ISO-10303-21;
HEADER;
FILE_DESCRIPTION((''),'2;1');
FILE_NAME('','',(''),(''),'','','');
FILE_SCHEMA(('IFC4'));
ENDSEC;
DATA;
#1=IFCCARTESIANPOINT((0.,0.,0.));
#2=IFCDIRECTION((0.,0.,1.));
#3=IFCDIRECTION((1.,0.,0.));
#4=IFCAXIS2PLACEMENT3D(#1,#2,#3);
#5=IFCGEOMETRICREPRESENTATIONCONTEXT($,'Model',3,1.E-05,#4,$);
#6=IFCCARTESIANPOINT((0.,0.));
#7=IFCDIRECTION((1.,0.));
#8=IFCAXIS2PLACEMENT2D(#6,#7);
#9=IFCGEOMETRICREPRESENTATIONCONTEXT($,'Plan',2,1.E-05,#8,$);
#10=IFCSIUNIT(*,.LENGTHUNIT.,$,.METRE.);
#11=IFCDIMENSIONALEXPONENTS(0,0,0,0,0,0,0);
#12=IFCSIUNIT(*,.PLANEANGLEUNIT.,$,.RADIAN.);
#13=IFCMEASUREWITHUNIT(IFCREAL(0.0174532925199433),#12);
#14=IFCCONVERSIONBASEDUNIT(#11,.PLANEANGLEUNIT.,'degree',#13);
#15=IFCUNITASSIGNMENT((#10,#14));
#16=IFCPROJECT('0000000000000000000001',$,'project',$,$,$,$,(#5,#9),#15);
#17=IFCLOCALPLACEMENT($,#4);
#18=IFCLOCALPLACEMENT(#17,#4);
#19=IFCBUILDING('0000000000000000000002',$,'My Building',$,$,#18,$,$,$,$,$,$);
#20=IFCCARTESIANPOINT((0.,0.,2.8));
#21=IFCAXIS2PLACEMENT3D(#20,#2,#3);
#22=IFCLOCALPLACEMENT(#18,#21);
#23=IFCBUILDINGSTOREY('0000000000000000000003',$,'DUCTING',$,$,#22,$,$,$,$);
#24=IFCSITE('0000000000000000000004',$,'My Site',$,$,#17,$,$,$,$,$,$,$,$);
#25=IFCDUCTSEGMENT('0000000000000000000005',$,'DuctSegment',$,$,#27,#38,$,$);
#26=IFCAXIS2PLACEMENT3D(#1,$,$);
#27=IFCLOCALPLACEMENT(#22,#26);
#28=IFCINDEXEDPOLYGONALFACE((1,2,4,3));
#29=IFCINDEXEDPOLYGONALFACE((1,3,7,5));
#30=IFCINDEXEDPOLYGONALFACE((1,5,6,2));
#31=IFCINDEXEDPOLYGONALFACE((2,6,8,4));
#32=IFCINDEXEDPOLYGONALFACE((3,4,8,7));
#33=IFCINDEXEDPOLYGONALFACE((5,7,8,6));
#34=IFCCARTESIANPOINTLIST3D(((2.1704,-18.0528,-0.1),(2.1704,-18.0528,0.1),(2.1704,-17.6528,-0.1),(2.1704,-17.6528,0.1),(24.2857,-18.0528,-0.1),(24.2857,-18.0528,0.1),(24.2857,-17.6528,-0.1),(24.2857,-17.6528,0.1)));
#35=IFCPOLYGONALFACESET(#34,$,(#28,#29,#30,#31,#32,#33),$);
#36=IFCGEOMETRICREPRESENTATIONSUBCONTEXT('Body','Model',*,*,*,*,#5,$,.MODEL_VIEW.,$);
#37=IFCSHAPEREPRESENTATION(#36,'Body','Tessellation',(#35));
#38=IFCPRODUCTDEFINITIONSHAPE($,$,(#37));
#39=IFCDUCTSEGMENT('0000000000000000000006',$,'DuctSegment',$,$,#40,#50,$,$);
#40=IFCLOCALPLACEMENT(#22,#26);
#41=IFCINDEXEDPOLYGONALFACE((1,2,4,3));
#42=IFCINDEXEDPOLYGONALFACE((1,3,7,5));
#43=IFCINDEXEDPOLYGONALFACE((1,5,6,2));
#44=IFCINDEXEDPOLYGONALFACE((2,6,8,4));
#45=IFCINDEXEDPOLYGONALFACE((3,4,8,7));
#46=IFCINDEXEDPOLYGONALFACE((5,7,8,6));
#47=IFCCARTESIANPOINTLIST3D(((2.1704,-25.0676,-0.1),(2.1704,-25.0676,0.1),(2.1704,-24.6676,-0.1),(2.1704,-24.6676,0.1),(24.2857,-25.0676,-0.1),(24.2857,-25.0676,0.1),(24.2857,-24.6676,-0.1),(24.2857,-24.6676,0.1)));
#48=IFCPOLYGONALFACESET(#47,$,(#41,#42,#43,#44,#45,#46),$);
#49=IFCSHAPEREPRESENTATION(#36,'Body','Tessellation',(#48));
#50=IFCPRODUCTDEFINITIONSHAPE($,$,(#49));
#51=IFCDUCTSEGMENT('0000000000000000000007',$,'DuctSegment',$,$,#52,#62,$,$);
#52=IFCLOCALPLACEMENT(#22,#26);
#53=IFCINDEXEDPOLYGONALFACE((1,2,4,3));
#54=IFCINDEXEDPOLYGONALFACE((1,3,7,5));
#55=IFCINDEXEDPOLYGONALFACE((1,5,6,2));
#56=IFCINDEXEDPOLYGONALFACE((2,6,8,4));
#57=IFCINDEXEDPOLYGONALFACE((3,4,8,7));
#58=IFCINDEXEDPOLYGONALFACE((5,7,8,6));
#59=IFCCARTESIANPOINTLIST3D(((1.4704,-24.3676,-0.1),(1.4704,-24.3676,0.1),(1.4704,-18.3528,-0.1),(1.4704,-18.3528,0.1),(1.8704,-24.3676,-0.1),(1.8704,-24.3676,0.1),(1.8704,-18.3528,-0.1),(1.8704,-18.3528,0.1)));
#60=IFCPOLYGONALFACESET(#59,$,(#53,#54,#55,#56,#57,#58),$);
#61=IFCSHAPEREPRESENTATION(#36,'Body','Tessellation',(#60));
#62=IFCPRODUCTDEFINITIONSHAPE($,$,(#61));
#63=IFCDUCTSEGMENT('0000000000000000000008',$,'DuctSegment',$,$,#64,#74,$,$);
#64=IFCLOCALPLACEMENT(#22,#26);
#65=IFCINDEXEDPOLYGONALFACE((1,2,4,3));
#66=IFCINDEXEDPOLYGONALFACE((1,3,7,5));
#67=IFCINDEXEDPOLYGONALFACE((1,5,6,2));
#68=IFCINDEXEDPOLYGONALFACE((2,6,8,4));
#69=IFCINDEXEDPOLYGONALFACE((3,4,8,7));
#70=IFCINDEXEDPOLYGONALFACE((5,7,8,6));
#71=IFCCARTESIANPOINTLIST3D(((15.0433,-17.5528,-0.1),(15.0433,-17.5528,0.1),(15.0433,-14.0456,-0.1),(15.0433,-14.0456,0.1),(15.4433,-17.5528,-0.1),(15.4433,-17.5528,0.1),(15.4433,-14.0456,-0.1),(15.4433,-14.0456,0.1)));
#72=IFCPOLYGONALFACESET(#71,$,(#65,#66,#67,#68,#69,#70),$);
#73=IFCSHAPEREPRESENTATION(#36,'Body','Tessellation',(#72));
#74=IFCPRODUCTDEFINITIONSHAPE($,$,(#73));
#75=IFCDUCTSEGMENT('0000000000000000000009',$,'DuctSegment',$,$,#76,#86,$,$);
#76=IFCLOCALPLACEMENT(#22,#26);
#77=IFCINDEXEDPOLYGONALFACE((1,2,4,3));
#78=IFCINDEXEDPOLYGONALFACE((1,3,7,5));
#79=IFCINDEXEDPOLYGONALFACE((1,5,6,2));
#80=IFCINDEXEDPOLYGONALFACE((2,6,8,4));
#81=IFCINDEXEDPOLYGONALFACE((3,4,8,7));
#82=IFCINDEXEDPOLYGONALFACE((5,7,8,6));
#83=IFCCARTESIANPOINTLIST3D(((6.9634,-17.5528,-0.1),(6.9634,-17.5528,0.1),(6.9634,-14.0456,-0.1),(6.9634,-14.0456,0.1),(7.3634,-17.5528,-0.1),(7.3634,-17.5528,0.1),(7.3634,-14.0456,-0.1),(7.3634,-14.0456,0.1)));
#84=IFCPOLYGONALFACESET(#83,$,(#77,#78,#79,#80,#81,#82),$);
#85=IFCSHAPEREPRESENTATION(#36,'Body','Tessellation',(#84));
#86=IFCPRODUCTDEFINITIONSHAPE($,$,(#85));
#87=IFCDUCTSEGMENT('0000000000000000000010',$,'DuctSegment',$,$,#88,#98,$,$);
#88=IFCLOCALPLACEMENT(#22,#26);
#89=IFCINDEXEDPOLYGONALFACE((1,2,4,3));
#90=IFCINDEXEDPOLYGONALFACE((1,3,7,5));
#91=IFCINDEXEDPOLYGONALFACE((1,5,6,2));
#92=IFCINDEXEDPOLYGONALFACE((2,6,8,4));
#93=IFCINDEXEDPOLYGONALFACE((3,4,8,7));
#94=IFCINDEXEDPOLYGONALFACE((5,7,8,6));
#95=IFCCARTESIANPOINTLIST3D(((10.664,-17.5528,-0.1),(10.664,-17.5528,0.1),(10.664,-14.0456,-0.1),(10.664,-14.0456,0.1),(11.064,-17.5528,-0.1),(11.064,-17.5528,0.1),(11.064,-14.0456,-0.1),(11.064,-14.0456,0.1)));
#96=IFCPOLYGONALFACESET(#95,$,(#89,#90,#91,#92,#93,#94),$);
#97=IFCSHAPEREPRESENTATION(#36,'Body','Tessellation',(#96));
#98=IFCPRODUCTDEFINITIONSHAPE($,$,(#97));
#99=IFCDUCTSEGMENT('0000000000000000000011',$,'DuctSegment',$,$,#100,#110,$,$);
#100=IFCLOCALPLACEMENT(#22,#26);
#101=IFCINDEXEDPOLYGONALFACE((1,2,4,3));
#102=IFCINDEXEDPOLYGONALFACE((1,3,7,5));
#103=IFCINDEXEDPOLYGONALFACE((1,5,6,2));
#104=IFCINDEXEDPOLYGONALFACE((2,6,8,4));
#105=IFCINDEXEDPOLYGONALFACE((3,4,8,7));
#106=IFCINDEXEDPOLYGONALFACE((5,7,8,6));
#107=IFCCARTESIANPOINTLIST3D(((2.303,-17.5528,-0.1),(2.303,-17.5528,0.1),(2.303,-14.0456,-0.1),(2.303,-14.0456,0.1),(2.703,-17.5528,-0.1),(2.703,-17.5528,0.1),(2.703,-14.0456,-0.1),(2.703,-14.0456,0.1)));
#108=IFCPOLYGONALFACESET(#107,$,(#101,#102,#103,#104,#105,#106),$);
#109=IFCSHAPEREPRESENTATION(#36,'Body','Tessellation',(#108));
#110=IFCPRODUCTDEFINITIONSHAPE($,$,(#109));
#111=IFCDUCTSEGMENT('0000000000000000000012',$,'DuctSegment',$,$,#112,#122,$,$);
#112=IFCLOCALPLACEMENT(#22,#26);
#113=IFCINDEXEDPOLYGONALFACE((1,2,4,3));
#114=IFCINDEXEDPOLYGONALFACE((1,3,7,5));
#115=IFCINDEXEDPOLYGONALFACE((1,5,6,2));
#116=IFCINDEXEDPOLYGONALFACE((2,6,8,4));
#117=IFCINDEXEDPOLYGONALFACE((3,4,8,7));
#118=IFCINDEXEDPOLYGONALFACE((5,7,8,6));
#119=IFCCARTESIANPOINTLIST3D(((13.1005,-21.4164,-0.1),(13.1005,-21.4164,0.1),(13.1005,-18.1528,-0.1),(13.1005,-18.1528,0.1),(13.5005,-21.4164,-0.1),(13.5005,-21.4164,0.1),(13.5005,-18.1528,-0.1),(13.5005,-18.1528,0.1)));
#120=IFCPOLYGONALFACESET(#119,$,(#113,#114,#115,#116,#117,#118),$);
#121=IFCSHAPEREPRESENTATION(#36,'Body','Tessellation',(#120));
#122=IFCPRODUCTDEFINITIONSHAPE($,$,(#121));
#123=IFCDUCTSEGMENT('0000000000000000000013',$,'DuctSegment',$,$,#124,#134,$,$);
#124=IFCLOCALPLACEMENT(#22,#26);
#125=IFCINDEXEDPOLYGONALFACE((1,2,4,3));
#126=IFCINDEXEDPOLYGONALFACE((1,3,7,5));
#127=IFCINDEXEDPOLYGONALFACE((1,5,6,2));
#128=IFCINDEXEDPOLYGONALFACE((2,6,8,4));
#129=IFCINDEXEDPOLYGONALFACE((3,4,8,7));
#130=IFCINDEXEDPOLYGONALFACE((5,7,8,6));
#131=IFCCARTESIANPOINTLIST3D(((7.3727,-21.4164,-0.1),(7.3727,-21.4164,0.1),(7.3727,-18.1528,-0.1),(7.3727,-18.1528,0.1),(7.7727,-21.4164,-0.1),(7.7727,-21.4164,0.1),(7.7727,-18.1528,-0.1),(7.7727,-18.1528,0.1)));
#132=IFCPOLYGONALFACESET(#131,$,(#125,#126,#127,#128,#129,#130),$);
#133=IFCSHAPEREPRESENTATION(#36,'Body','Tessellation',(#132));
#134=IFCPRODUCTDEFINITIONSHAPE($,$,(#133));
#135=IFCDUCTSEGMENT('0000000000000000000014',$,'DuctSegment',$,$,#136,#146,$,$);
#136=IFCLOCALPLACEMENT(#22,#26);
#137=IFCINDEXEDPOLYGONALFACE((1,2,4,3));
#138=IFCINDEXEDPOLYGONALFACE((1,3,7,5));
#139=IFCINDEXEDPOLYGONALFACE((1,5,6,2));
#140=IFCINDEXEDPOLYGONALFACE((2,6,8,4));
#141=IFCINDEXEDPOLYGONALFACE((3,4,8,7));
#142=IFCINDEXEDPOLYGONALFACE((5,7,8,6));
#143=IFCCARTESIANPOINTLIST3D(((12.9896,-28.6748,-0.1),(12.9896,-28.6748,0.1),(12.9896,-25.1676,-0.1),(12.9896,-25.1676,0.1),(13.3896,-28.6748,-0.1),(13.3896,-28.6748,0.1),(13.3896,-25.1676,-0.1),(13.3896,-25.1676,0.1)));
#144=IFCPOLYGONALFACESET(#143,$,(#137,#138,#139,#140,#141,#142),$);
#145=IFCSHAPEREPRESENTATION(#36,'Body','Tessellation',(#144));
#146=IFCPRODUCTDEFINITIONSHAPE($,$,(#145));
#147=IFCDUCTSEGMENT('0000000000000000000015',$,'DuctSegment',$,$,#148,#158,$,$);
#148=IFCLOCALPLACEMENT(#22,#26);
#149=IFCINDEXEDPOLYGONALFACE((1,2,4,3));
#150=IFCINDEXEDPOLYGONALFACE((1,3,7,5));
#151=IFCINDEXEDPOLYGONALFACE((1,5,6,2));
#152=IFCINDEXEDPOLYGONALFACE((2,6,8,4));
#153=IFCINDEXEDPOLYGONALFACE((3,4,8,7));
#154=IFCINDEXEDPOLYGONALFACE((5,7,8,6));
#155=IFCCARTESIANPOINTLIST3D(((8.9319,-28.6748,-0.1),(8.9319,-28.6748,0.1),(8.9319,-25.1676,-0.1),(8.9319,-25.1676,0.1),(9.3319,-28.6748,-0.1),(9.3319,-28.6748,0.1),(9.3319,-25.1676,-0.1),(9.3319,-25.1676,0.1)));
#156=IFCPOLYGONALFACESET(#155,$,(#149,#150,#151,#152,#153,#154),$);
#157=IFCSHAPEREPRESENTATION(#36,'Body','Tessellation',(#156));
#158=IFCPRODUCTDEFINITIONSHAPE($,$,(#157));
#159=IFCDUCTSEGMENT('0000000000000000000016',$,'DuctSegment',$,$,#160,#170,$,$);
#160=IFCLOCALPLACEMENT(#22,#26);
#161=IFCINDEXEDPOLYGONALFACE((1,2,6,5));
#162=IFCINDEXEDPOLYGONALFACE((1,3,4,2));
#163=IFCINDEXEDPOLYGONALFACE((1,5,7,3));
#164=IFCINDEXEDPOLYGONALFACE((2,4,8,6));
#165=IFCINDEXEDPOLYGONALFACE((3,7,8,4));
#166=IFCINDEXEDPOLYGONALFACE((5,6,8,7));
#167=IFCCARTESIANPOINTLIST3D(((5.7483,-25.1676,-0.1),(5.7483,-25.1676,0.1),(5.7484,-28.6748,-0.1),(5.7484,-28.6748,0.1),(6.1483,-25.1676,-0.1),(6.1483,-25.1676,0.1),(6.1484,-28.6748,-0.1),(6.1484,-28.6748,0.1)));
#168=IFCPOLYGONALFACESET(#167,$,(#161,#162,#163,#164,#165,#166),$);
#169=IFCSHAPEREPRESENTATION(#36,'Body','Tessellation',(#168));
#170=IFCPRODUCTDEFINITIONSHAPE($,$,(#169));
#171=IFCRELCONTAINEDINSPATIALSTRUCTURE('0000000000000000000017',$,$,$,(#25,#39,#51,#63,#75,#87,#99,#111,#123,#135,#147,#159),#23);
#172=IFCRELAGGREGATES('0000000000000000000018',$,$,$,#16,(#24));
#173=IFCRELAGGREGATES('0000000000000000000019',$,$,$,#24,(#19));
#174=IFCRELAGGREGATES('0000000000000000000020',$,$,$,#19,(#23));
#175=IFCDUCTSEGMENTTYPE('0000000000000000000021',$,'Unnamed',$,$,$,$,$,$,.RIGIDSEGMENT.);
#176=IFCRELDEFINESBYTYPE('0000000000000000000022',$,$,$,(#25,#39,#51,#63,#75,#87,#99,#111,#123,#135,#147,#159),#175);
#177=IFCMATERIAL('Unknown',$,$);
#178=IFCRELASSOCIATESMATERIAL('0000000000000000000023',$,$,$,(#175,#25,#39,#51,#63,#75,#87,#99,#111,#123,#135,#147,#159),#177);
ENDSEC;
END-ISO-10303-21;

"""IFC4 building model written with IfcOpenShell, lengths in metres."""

from ifc_helpers import new_model, entity, si_unit, converted_unit, frame, origin_with_axes, origin_2d_with_axis, place, context, subcontext, project, spatial, rectangle, extrude, material, material_profile, profile_set, profile_usage, type_object, element, save


model = new_model("IFC4")

# Units and contexts
model_context = context("Model", 3, precision=1e-05, world=origin_with_axes())
plan_context = context("Plan", 2, precision=1e-05, world=origin_2d_with_axis())
body_context = subcontext(model_context, "Body", "Model", "MODEL_VIEW")
ifc_project = project(units=[si_unit("LENGTHUNIT", "METRE"), converted_unit("PLANEANGLEUNIT", "degree", entity("IfcReal", 0.0174532925199433), si_unit("PLANEANGLEUNIT", "RADIAN"), dimensions=[0, 0, 0, 0, 0, 0, 0])], contexts=[model_context, plan_context])

# Site, building, storey
site_placement = place(None, origin_with_axes())
site = spatial("IfcSite", under=ifc_project, at=site_placement, Name="My Site")
building_placement = place(site_placement, origin_with_axes())
building = spatial("IfcBuilding", under=site, at=building_placement, Name="My Building")
storey_placement = place(building_placement, frame((0.0, 0.0, 2.8), z_axis=(0.0, 0.0, 1.0), x_axis=(1.0, 0.0, 0.0)))
storey = spatial("IfcBuildingStorey", under=building, at=storey_placement, Name="DUCTING")

# Duct segments
ifc_material = material(Name="Unknown")
ifc_material_profile_1 = material_profile(ifc_material, rectangle(XDim=0.4, YDim=0.2))
ifc_profile_set_1 = profile_set([ifc_material_profile_1])
ifc_profile_usage_1 = profile_usage(ifc_profile_set_1, cardinal=5)
duct_segment_type = type_object("IfcDuctSegmentType", Name="Unnamed", PredefinedType="RIGIDSEGMENT", material=ifc_profile_set_1)
duct_segment_1_placement = place(storey_placement, frame((2.1704, -17.8528, 0.0), z_axis=(1.0, -0.000001, 0.000001), x_axis=(0.000001, 1.0, 0.0)))
element("IfcDuctSegment", 1, at=duct_segment_1_placement, inside=storey, type_object=duct_segment_type, material=ifc_profile_usage_1, Name="DuctSegment", context=body_context, shape_type="SweptSolid", body=[
    extrude(rectangle(XDim=0.4, YDim=0.2), origin_with_axes(), (0.0, 0.0, 1.0), 22.1154),
])
ifc_profile_usage_2 = profile_usage(ifc_profile_set_1, cardinal=5)
duct_segment_2_placement = place(storey_placement, frame((2.1704, -24.8676, 0.0), z_axis=(1.0, -0.000001, 0.000001), x_axis=(0.000001, 1.0, 0.0)))
element("IfcDuctSegment", 2, at=duct_segment_2_placement, inside=storey, type_object=duct_segment_type, material=ifc_profile_usage_2, Name="DuctSegment", context=body_context, shape_type="SweptSolid", body=[
    extrude(rectangle(XDim=0.4, YDim=0.2), origin_with_axes(), (0.0, 0.0, 1.0), 22.1154),
])
ifc_profile_usage_3 = profile_usage(ifc_profile_set_1, cardinal=5)
duct_segment_3_placement = place(storey_placement, frame((1.6704, -18.3528, 0.0), z_axis=(0.0, -1.0, 0.0), x_axis=(1.0, 0.0, 0.0)))
element("IfcDuctSegment", 3, at=duct_segment_3_placement, inside=storey, type_object=duct_segment_type, material=ifc_profile_usage_3, Name="DuctSegment", context=body_context, shape_type="SweptSolid", body=[
    extrude(rectangle(XDim=0.4, YDim=0.2), origin_with_axes(), (0.0, 0.0, 1.0), 6.0148),
])
ifc_profile_usage_4 = profile_usage(ifc_profile_set_1, cardinal=5)
duct_segment_4_placement = place(storey_placement, frame((15.2433, -17.5528, 0.0), z_axis=(0.0, 1.0, 0.0), x_axis=(-1.0, 0.0, 0.0)))
element("IfcDuctSegment", 4, at=duct_segment_4_placement, inside=storey, type_object=duct_segment_type, material=ifc_profile_usage_4, Name="DuctSegment", context=body_context, shape_type="SweptSolid", body=[
    extrude(rectangle(XDim=0.4, YDim=0.2), origin_with_axes(), (0.0, 0.0, 1.0), 3.5072),
])
ifc_profile_usage_5 = profile_usage(ifc_profile_set_1, cardinal=5)
duct_segment_5_placement = place(storey_placement, frame((7.1634, -17.5528, 0.0), z_axis=(0.0, 1.0, 0.0), x_axis=(-1.0, 0.0, 0.0)))
element("IfcDuctSegment", 5, at=duct_segment_5_placement, inside=storey, type_object=duct_segment_type, material=ifc_profile_usage_5, Name="DuctSegment", context=body_context, shape_type="SweptSolid", body=[
    extrude(rectangle(XDim=0.4, YDim=0.2), origin_with_axes(), (0.0, 0.0, 1.0), 3.5072),
])
ifc_profile_usage_6 = profile_usage(ifc_profile_set_1, cardinal=5)
duct_segment_6_placement = place(storey_placement, frame((10.864, -17.5528, 0.0), z_axis=(0.0, 1.0, 0.0), x_axis=(-1.0, 0.0, 0.0)))
element("IfcDuctSegment", 6, at=duct_segment_6_placement, inside=storey, type_object=duct_segment_type, material=ifc_profile_usage_6, Name="DuctSegment", context=body_context, shape_type="SweptSolid", body=[
    extrude(rectangle(XDim=0.4, YDim=0.2), origin_with_axes(), (0.0, 0.0, 1.0), 3.5072),
])
ifc_profile_usage_7 = profile_usage(ifc_profile_set_1, cardinal=5)
duct_segment_7_placement = place(storey_placement, frame((2.503, -17.5528, 0.0), z_axis=(0.0, 1.0, 0.0), x_axis=(-1.0, 0.0, 0.0)))
element("IfcDuctSegment", 7, at=duct_segment_7_placement, inside=storey, type_object=duct_segment_type, material=ifc_profile_usage_7, Name="DuctSegment", context=body_context, shape_type="SweptSolid", body=[
    extrude(rectangle(XDim=0.4, YDim=0.2), origin_with_axes(), (0.0, 0.0, 1.0), 3.5072),
])
ifc_profile_usage_8 = profile_usage(ifc_profile_set_1, cardinal=5)
duct_segment_8_placement = place(storey_placement, frame((13.3005, -18.1528, 0.0), z_axis=(0.0, -1.0, 0.0), x_axis=(1.0, 0.0, 0.0)))
element("IfcDuctSegment", 8, at=duct_segment_8_placement, inside=storey, type_object=duct_segment_type, material=ifc_profile_usage_8, Name="DuctSegment", context=body_context, shape_type="SweptSolid", body=[
    extrude(rectangle(XDim=0.4, YDim=0.2), origin_with_axes(), (0.0, 0.0, 1.0), 3.2636),
])
ifc_profile_usage_9 = profile_usage(ifc_profile_set_1, cardinal=5)
duct_segment_9_placement = place(storey_placement, frame((7.5727, -18.1528, 0.0), z_axis=(0.0, -1.0, 0.0), x_axis=(1.0, 0.0, 0.0)))
element("IfcDuctSegment", 9, at=duct_segment_9_placement, inside=storey, type_object=duct_segment_type, material=ifc_profile_usage_9, Name="DuctSegment", context=body_context, shape_type="SweptSolid", body=[
    extrude(rectangle(XDim=0.4, YDim=0.2), origin_with_axes(), (0.0, 0.0, 1.0), 3.2636),
])
ifc_profile_usage_10 = profile_usage(ifc_profile_set_1, cardinal=5)
duct_segment_10_placement = place(storey_placement, frame((13.1896, -25.1676, 0.0), z_axis=(0.0, -1.0, 0.0), x_axis=(1.0, 0.0, 0.0)))
element("IfcDuctSegment", 10, at=duct_segment_10_placement, inside=storey, type_object=duct_segment_type, material=ifc_profile_usage_10, Name="DuctSegment", context=body_context, shape_type="SweptSolid", body=[
    extrude(rectangle(XDim=0.4, YDim=0.2), origin_with_axes(), (0.0, 0.0, 1.0), 3.5072),
])
ifc_profile_usage_11 = profile_usage(ifc_profile_set_1, cardinal=5)
duct_segment_11_placement = place(storey_placement, frame((9.1319, -25.1676, 0.0), z_axis=(0.0, -1.0, 0.0), x_axis=(1.0, 0.0, 0.0)))
element("IfcDuctSegment", 11, at=duct_segment_11_placement, inside=storey, type_object=duct_segment_type, material=ifc_profile_usage_11, Name="DuctSegment", context=body_context, shape_type="SweptSolid", body=[
    extrude(rectangle(XDim=0.4, YDim=0.2), origin_with_axes(), (0.0, 0.0, 1.0), 3.5072),
])
ifc_profile_usage_12 = profile_usage(ifc_profile_set_1, cardinal=5)
duct_segment_12_placement = place(storey_placement, frame((5.9483, -25.1676, 0.0), z_axis=(0.0, -1.0, 0.0), x_axis=(1.0, 0.0, 0.0)))
element("IfcDuctSegment", 12, at=duct_segment_12_placement, inside=storey, type_object=duct_segment_type, material=ifc_profile_usage_12, Name="DuctSegment", context=body_context, shape_type="SweptSolid", body=[
    extrude(rectangle(XDim=0.4, YDim=0.2), origin_with_axes(), (0.0, 0.0, 1.0), 3.5072),
])

save(model, "model.ifc")
